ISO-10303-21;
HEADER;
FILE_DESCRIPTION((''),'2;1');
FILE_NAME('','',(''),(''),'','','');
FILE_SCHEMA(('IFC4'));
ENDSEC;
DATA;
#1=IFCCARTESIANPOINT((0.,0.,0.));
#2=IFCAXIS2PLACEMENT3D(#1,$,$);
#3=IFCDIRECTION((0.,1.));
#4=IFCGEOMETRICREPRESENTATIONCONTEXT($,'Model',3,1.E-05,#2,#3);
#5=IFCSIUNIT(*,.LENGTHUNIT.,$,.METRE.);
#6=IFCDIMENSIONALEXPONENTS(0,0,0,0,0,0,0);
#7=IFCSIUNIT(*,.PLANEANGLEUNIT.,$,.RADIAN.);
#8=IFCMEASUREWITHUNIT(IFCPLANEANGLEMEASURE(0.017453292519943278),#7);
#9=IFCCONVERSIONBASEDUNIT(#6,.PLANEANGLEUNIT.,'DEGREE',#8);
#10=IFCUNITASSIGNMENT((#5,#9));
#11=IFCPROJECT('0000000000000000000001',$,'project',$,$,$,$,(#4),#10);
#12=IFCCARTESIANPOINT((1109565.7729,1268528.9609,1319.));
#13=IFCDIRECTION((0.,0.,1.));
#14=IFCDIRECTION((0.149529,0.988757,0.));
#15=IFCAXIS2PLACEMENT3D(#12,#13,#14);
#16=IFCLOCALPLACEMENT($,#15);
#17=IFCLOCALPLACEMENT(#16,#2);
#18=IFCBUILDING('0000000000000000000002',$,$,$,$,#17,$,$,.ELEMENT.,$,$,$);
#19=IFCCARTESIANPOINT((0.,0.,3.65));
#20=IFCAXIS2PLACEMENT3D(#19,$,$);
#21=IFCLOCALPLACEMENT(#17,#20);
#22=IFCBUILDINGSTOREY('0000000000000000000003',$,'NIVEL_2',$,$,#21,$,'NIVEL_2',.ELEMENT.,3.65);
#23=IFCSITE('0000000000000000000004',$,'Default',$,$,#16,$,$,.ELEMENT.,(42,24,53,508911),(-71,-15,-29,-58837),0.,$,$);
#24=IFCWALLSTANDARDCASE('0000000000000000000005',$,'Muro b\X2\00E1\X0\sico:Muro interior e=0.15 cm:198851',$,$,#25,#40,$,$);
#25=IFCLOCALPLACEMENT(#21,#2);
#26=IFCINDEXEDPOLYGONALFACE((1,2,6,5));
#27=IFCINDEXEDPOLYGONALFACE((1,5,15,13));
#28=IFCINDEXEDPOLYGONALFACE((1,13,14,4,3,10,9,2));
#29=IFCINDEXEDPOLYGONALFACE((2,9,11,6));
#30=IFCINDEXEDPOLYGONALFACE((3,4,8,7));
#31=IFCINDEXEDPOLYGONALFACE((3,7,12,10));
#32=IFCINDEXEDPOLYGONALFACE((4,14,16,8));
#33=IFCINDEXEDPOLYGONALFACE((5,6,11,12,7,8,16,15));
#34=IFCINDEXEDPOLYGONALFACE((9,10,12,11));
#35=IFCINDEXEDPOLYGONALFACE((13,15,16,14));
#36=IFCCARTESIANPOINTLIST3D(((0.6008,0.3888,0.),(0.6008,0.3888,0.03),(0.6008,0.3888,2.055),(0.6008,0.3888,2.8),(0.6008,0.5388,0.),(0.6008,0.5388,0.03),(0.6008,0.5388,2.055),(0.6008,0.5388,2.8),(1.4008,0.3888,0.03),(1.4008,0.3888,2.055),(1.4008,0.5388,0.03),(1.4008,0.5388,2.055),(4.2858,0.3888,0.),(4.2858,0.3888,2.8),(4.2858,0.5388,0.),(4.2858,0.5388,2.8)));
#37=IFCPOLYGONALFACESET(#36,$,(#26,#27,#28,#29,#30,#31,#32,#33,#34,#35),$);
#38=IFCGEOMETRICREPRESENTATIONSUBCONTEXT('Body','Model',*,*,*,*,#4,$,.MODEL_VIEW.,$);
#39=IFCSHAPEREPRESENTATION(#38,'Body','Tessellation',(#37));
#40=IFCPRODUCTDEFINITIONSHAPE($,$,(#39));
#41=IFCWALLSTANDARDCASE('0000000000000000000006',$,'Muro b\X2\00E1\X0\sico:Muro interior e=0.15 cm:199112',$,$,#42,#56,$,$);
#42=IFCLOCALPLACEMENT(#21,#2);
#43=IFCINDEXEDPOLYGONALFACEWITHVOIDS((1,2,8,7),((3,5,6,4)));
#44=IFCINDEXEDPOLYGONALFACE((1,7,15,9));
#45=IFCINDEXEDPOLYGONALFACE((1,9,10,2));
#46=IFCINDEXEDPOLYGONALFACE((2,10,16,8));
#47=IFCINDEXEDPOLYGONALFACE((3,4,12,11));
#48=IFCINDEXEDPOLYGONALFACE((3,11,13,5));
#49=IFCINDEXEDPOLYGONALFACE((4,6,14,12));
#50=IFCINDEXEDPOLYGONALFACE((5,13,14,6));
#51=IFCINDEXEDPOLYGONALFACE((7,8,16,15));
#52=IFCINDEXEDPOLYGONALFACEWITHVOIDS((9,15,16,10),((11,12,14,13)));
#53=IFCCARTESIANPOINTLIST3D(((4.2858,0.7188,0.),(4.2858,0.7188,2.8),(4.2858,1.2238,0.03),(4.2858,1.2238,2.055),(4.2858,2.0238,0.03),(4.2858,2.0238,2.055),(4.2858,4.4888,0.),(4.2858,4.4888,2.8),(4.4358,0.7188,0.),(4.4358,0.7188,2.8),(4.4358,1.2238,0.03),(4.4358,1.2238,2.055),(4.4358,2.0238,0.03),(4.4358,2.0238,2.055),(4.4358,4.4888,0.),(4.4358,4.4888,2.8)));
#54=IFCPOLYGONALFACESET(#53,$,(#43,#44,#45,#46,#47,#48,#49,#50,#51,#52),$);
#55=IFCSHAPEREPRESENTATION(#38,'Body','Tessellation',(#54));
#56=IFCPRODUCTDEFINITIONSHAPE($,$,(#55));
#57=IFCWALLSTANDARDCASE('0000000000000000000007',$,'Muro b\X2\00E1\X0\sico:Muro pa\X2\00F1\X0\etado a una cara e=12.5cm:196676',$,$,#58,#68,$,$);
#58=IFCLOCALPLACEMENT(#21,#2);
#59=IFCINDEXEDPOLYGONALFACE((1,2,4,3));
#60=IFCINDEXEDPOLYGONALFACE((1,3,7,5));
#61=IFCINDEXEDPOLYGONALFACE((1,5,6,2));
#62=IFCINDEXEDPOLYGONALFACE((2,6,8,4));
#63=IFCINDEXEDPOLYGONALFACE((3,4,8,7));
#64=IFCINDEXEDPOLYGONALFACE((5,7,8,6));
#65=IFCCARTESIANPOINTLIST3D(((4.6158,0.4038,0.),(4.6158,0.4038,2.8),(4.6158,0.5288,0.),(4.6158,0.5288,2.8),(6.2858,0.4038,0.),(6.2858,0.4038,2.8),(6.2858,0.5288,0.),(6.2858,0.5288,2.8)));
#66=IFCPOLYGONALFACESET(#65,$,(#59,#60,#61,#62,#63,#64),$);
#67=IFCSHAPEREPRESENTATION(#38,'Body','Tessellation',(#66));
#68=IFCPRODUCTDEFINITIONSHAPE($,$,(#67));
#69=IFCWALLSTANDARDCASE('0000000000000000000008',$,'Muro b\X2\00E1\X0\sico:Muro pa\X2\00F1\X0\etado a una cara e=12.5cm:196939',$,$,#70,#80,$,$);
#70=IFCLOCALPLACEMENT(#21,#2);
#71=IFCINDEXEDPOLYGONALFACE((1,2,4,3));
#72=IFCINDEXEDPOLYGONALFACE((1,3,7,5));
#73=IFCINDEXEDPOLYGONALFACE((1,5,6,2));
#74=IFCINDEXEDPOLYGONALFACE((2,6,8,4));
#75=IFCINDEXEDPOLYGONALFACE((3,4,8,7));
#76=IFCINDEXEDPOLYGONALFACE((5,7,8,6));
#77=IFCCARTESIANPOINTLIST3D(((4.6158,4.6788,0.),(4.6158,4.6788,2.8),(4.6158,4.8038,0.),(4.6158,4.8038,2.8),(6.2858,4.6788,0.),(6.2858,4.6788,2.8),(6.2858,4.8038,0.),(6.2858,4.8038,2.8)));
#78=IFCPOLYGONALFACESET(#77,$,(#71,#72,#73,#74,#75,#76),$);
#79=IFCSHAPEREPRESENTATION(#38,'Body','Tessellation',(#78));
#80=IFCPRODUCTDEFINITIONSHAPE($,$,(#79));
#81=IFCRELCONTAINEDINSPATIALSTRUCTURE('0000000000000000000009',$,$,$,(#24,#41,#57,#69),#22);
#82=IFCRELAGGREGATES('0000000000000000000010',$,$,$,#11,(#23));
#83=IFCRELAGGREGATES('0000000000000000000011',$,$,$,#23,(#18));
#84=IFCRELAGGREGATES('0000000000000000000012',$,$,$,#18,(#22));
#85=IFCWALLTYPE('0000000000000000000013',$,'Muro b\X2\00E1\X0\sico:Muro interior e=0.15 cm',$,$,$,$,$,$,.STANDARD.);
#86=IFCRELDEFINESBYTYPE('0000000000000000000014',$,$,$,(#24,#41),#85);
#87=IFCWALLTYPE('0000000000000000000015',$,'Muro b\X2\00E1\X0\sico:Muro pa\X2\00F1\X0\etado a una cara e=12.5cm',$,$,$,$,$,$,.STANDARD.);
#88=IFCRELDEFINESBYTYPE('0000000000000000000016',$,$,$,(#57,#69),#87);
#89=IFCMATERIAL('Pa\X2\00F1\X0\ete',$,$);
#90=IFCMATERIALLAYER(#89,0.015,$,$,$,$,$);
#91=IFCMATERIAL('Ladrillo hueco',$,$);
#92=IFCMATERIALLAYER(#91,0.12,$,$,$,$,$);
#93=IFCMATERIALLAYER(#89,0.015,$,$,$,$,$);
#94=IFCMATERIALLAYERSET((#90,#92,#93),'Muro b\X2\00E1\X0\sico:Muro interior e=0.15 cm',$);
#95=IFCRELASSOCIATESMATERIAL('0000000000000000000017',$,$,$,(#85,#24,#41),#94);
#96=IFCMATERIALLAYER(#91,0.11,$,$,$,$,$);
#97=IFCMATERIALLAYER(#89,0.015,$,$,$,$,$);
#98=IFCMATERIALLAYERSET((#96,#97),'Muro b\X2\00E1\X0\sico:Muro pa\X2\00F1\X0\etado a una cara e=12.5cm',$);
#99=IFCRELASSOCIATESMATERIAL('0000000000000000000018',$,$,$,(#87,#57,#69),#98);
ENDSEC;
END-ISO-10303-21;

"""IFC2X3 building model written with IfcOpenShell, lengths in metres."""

from ifc_helpers import new_model, entity, si_unit, converted_unit, direction, frame, frame_2d, origin, place, context, subcontext, project, spatial, rectangle, extrude, material, layer, layer_set, layer_usage, type_object, element, save


model = new_model("IFC2X3")

# Units and contexts
model_context = context("Model", 3, precision=1e-05, world=origin(), true_north=direction((0.0, 1.0)))
body_context = subcontext(model_context, "Body", "Model", "MODEL_VIEW")
ifc_project = project(units=[si_unit("LENGTHUNIT", "METRE"), converted_unit("PLANEANGLEUNIT", "DEGREE", entity("IfcPlaneAngleMeasure", 0.017453292519943278), si_unit("PLANEANGLEUNIT", "RADIAN"), dimensions=[0, 0, 0, 0, 0, 0, 0])], contexts=[model_context])

# Site, building, storey
site_placement = place(None, frame((1109565.7729, 1268528.9609, 1319.0), z_axis=(0.0, 0.0, 1.0), x_axis=(0.149529, 0.988757, 0.0)))
site = spatial("IfcSite", under=ifc_project, at=site_placement, Name="Default", CompositionType="ELEMENT", RefLatitude=(42, 24, 53, 508911), RefLongitude=(-71, -15, -29, -58837), RefElevation=0.0)
building_placement = place(site_placement, origin())
building = spatial("IfcBuilding", under=site, at=building_placement, CompositionType="ELEMENT")
storey_placement = place(building_placement, frame((0.0, 0.0, 3.65)))
storey = spatial("IfcBuildingStorey", under=building, at=storey_placement, Name="NIVEL_2", LongName="NIVEL_2", CompositionType="ELEMENT", Elevation=3.65)

# Walls, openings
ifc_material_1 = material(Name="Pañete")
ifc_layer_1 = layer(ifc_material_1, 0.015)
ifc_material_2 = material(Name="Ladrillo hueco")
ifc_layer_2 = layer(ifc_material_2, 0.12)
ifc_layer_3 = layer(ifc_material_1, 0.015)
ifc_layer_set_1 = layer_set([ifc_layer_1, ifc_layer_2, ifc_layer_3], Name="Muro básico:Muro interior e=0.15 cm")
ifc_layer_usage_1 = layer_usage(ifc_layer_set_1, "AXIS2", "NEGATIVE", 0.075)
wall_type_1 = type_object("IfcWallType", Name="Muro básico:Muro interior e=0.15 cm", PredefinedType="STANDARD", material=ifc_layer_set_1)
wall_1_placement = place(storey_placement, frame((4.2858, 0.4638, 0.0), z_axis=(0.0, 0.0, 1.0), x_axis=(-1.0, 0.0, 0.0)))
wall_1 = element("IfcWallStandardCase", 1, at=wall_1_placement, inside=storey, type_object=wall_type_1, material=ifc_layer_usage_1, Name="Muro básico:Muro interior e=0.15 cm:198851", context=body_context, shape_type="SweptSolid", body=[
    extrude(rectangle(XDim=3.685, YDim=0.15, at=frame_2d((1.8425, 0.0), x_axis=(-1.0, 0.0))), origin(), (0.0, 0.0, 1.0), 2.8),
])
opening_1_placement = place(wall_1_placement, frame((3.685, 0.075, 0.03)))
element("IfcOpeningElement", 2, at=opening_1_placement, cuts=wall_1, ObjectType="Opening", context=body_context, shape_type="SweptSolid", body=[
    extrude(rectangle(XDim=2.025, YDim=0.8, at=frame_2d((1.0125, 0.4), x_axis=(1.0, 0.0))), frame((0.0, 0.0, 0.0), z_axis=(0.0, -1.0, 0.0), x_axis=(0.0, 0.0, 1.0)), (0.0, 0.0, 1.0), 0.15),
])
ifc_layer_usage_2 = layer_usage(ifc_layer_set_1, "AXIS2", "NEGATIVE", 0.075)
wall_2_placement = place(storey_placement, frame((4.3608, 0.7188, 0.0), z_axis=(0.0, 0.0, 1.0), x_axis=(0.0, 1.0, 0.0)))
wall_2 = element("IfcWallStandardCase", 3, at=wall_2_placement, inside=storey, type_object=wall_type_1, material=ifc_layer_usage_2, Name="Muro básico:Muro interior e=0.15 cm:199112", context=body_context, shape_type="SweptSolid", body=[
    extrude(rectangle(XDim=3.77, YDim=0.15, at=frame_2d((1.885, 0.0), x_axis=(-1.0, 0.0))), origin(), (0.0, 0.0, 1.0), 2.8),
])
opening_2_placement = place(wall_2_placement, frame((1.305, 0.075, 0.03)))
element("IfcOpeningElement", 4, at=opening_2_placement, cuts=wall_2, ObjectType="Opening", context=body_context, shape_type="SweptSolid", body=[
    extrude(rectangle(XDim=2.025, YDim=0.8, at=frame_2d((1.0125, 0.4), x_axis=(1.0, 0.0))), frame((0.0, 0.0, 0.0), z_axis=(0.0, -1.0, 0.0), x_axis=(0.0, 0.0, 1.0)), (0.0, 0.0, 1.0), 0.15),
])

# Wall
ifc_layer_4 = layer(ifc_material_2, 0.11)
ifc_layer_5 = layer(ifc_material_1, 0.015)
ifc_layer_set_2 = layer_set([ifc_layer_4, ifc_layer_5], Name="Muro básico:Muro pañetado a una cara e=12.5cm")
ifc_layer_usage_3 = layer_usage(ifc_layer_set_2, "AXIS2", "POSITIVE", -0.0625)
wall_type_2 = type_object("IfcWallType", Name="Muro básico:Muro pañetado a una cara e=12.5cm", PredefinedType="STANDARD", material=ifc_layer_set_2)
wall_3_placement = place(storey_placement, frame((4.6158, 0.4663, 0.0)))
element("IfcWallStandardCase", 5, at=wall_3_placement, inside=storey, type_object=wall_type_2, material=ifc_layer_usage_3, Name="Muro básico:Muro pañetado a una cara e=12.5cm:196676", context=body_context, shape_type="SweptSolid", body=[
    extrude(rectangle(XDim=1.67, YDim=0.125, at=frame_2d((0.835, 0.0), x_axis=(-1.0, 0.0))), origin(), (0.0, 0.0, 1.0), 2.8),
])

# Wall
ifc_layer_usage_4 = layer_usage(ifc_layer_set_2, "AXIS2", "POSITIVE", -0.0625)
wall_4_placement = place(storey_placement, frame((6.2858, 4.7413, 0.0), z_axis=(0.0, 0.0, 1.0), x_axis=(-1.0, 0.0, 0.0)))
element("IfcWallStandardCase", 6, at=wall_4_placement, inside=storey, type_object=wall_type_2, material=ifc_layer_usage_4, Name="Muro básico:Muro pañetado a una cara e=12.5cm:196939", context=body_context, shape_type="SweptSolid", body=[
    extrude(rectangle(XDim=1.67, YDim=0.125, at=frame_2d((0.835, 0.0), x_axis=(-1.0, 0.0))), origin(), (0.0, 0.0, 1.0), 2.8),
])

save(model, "model.ifc")
